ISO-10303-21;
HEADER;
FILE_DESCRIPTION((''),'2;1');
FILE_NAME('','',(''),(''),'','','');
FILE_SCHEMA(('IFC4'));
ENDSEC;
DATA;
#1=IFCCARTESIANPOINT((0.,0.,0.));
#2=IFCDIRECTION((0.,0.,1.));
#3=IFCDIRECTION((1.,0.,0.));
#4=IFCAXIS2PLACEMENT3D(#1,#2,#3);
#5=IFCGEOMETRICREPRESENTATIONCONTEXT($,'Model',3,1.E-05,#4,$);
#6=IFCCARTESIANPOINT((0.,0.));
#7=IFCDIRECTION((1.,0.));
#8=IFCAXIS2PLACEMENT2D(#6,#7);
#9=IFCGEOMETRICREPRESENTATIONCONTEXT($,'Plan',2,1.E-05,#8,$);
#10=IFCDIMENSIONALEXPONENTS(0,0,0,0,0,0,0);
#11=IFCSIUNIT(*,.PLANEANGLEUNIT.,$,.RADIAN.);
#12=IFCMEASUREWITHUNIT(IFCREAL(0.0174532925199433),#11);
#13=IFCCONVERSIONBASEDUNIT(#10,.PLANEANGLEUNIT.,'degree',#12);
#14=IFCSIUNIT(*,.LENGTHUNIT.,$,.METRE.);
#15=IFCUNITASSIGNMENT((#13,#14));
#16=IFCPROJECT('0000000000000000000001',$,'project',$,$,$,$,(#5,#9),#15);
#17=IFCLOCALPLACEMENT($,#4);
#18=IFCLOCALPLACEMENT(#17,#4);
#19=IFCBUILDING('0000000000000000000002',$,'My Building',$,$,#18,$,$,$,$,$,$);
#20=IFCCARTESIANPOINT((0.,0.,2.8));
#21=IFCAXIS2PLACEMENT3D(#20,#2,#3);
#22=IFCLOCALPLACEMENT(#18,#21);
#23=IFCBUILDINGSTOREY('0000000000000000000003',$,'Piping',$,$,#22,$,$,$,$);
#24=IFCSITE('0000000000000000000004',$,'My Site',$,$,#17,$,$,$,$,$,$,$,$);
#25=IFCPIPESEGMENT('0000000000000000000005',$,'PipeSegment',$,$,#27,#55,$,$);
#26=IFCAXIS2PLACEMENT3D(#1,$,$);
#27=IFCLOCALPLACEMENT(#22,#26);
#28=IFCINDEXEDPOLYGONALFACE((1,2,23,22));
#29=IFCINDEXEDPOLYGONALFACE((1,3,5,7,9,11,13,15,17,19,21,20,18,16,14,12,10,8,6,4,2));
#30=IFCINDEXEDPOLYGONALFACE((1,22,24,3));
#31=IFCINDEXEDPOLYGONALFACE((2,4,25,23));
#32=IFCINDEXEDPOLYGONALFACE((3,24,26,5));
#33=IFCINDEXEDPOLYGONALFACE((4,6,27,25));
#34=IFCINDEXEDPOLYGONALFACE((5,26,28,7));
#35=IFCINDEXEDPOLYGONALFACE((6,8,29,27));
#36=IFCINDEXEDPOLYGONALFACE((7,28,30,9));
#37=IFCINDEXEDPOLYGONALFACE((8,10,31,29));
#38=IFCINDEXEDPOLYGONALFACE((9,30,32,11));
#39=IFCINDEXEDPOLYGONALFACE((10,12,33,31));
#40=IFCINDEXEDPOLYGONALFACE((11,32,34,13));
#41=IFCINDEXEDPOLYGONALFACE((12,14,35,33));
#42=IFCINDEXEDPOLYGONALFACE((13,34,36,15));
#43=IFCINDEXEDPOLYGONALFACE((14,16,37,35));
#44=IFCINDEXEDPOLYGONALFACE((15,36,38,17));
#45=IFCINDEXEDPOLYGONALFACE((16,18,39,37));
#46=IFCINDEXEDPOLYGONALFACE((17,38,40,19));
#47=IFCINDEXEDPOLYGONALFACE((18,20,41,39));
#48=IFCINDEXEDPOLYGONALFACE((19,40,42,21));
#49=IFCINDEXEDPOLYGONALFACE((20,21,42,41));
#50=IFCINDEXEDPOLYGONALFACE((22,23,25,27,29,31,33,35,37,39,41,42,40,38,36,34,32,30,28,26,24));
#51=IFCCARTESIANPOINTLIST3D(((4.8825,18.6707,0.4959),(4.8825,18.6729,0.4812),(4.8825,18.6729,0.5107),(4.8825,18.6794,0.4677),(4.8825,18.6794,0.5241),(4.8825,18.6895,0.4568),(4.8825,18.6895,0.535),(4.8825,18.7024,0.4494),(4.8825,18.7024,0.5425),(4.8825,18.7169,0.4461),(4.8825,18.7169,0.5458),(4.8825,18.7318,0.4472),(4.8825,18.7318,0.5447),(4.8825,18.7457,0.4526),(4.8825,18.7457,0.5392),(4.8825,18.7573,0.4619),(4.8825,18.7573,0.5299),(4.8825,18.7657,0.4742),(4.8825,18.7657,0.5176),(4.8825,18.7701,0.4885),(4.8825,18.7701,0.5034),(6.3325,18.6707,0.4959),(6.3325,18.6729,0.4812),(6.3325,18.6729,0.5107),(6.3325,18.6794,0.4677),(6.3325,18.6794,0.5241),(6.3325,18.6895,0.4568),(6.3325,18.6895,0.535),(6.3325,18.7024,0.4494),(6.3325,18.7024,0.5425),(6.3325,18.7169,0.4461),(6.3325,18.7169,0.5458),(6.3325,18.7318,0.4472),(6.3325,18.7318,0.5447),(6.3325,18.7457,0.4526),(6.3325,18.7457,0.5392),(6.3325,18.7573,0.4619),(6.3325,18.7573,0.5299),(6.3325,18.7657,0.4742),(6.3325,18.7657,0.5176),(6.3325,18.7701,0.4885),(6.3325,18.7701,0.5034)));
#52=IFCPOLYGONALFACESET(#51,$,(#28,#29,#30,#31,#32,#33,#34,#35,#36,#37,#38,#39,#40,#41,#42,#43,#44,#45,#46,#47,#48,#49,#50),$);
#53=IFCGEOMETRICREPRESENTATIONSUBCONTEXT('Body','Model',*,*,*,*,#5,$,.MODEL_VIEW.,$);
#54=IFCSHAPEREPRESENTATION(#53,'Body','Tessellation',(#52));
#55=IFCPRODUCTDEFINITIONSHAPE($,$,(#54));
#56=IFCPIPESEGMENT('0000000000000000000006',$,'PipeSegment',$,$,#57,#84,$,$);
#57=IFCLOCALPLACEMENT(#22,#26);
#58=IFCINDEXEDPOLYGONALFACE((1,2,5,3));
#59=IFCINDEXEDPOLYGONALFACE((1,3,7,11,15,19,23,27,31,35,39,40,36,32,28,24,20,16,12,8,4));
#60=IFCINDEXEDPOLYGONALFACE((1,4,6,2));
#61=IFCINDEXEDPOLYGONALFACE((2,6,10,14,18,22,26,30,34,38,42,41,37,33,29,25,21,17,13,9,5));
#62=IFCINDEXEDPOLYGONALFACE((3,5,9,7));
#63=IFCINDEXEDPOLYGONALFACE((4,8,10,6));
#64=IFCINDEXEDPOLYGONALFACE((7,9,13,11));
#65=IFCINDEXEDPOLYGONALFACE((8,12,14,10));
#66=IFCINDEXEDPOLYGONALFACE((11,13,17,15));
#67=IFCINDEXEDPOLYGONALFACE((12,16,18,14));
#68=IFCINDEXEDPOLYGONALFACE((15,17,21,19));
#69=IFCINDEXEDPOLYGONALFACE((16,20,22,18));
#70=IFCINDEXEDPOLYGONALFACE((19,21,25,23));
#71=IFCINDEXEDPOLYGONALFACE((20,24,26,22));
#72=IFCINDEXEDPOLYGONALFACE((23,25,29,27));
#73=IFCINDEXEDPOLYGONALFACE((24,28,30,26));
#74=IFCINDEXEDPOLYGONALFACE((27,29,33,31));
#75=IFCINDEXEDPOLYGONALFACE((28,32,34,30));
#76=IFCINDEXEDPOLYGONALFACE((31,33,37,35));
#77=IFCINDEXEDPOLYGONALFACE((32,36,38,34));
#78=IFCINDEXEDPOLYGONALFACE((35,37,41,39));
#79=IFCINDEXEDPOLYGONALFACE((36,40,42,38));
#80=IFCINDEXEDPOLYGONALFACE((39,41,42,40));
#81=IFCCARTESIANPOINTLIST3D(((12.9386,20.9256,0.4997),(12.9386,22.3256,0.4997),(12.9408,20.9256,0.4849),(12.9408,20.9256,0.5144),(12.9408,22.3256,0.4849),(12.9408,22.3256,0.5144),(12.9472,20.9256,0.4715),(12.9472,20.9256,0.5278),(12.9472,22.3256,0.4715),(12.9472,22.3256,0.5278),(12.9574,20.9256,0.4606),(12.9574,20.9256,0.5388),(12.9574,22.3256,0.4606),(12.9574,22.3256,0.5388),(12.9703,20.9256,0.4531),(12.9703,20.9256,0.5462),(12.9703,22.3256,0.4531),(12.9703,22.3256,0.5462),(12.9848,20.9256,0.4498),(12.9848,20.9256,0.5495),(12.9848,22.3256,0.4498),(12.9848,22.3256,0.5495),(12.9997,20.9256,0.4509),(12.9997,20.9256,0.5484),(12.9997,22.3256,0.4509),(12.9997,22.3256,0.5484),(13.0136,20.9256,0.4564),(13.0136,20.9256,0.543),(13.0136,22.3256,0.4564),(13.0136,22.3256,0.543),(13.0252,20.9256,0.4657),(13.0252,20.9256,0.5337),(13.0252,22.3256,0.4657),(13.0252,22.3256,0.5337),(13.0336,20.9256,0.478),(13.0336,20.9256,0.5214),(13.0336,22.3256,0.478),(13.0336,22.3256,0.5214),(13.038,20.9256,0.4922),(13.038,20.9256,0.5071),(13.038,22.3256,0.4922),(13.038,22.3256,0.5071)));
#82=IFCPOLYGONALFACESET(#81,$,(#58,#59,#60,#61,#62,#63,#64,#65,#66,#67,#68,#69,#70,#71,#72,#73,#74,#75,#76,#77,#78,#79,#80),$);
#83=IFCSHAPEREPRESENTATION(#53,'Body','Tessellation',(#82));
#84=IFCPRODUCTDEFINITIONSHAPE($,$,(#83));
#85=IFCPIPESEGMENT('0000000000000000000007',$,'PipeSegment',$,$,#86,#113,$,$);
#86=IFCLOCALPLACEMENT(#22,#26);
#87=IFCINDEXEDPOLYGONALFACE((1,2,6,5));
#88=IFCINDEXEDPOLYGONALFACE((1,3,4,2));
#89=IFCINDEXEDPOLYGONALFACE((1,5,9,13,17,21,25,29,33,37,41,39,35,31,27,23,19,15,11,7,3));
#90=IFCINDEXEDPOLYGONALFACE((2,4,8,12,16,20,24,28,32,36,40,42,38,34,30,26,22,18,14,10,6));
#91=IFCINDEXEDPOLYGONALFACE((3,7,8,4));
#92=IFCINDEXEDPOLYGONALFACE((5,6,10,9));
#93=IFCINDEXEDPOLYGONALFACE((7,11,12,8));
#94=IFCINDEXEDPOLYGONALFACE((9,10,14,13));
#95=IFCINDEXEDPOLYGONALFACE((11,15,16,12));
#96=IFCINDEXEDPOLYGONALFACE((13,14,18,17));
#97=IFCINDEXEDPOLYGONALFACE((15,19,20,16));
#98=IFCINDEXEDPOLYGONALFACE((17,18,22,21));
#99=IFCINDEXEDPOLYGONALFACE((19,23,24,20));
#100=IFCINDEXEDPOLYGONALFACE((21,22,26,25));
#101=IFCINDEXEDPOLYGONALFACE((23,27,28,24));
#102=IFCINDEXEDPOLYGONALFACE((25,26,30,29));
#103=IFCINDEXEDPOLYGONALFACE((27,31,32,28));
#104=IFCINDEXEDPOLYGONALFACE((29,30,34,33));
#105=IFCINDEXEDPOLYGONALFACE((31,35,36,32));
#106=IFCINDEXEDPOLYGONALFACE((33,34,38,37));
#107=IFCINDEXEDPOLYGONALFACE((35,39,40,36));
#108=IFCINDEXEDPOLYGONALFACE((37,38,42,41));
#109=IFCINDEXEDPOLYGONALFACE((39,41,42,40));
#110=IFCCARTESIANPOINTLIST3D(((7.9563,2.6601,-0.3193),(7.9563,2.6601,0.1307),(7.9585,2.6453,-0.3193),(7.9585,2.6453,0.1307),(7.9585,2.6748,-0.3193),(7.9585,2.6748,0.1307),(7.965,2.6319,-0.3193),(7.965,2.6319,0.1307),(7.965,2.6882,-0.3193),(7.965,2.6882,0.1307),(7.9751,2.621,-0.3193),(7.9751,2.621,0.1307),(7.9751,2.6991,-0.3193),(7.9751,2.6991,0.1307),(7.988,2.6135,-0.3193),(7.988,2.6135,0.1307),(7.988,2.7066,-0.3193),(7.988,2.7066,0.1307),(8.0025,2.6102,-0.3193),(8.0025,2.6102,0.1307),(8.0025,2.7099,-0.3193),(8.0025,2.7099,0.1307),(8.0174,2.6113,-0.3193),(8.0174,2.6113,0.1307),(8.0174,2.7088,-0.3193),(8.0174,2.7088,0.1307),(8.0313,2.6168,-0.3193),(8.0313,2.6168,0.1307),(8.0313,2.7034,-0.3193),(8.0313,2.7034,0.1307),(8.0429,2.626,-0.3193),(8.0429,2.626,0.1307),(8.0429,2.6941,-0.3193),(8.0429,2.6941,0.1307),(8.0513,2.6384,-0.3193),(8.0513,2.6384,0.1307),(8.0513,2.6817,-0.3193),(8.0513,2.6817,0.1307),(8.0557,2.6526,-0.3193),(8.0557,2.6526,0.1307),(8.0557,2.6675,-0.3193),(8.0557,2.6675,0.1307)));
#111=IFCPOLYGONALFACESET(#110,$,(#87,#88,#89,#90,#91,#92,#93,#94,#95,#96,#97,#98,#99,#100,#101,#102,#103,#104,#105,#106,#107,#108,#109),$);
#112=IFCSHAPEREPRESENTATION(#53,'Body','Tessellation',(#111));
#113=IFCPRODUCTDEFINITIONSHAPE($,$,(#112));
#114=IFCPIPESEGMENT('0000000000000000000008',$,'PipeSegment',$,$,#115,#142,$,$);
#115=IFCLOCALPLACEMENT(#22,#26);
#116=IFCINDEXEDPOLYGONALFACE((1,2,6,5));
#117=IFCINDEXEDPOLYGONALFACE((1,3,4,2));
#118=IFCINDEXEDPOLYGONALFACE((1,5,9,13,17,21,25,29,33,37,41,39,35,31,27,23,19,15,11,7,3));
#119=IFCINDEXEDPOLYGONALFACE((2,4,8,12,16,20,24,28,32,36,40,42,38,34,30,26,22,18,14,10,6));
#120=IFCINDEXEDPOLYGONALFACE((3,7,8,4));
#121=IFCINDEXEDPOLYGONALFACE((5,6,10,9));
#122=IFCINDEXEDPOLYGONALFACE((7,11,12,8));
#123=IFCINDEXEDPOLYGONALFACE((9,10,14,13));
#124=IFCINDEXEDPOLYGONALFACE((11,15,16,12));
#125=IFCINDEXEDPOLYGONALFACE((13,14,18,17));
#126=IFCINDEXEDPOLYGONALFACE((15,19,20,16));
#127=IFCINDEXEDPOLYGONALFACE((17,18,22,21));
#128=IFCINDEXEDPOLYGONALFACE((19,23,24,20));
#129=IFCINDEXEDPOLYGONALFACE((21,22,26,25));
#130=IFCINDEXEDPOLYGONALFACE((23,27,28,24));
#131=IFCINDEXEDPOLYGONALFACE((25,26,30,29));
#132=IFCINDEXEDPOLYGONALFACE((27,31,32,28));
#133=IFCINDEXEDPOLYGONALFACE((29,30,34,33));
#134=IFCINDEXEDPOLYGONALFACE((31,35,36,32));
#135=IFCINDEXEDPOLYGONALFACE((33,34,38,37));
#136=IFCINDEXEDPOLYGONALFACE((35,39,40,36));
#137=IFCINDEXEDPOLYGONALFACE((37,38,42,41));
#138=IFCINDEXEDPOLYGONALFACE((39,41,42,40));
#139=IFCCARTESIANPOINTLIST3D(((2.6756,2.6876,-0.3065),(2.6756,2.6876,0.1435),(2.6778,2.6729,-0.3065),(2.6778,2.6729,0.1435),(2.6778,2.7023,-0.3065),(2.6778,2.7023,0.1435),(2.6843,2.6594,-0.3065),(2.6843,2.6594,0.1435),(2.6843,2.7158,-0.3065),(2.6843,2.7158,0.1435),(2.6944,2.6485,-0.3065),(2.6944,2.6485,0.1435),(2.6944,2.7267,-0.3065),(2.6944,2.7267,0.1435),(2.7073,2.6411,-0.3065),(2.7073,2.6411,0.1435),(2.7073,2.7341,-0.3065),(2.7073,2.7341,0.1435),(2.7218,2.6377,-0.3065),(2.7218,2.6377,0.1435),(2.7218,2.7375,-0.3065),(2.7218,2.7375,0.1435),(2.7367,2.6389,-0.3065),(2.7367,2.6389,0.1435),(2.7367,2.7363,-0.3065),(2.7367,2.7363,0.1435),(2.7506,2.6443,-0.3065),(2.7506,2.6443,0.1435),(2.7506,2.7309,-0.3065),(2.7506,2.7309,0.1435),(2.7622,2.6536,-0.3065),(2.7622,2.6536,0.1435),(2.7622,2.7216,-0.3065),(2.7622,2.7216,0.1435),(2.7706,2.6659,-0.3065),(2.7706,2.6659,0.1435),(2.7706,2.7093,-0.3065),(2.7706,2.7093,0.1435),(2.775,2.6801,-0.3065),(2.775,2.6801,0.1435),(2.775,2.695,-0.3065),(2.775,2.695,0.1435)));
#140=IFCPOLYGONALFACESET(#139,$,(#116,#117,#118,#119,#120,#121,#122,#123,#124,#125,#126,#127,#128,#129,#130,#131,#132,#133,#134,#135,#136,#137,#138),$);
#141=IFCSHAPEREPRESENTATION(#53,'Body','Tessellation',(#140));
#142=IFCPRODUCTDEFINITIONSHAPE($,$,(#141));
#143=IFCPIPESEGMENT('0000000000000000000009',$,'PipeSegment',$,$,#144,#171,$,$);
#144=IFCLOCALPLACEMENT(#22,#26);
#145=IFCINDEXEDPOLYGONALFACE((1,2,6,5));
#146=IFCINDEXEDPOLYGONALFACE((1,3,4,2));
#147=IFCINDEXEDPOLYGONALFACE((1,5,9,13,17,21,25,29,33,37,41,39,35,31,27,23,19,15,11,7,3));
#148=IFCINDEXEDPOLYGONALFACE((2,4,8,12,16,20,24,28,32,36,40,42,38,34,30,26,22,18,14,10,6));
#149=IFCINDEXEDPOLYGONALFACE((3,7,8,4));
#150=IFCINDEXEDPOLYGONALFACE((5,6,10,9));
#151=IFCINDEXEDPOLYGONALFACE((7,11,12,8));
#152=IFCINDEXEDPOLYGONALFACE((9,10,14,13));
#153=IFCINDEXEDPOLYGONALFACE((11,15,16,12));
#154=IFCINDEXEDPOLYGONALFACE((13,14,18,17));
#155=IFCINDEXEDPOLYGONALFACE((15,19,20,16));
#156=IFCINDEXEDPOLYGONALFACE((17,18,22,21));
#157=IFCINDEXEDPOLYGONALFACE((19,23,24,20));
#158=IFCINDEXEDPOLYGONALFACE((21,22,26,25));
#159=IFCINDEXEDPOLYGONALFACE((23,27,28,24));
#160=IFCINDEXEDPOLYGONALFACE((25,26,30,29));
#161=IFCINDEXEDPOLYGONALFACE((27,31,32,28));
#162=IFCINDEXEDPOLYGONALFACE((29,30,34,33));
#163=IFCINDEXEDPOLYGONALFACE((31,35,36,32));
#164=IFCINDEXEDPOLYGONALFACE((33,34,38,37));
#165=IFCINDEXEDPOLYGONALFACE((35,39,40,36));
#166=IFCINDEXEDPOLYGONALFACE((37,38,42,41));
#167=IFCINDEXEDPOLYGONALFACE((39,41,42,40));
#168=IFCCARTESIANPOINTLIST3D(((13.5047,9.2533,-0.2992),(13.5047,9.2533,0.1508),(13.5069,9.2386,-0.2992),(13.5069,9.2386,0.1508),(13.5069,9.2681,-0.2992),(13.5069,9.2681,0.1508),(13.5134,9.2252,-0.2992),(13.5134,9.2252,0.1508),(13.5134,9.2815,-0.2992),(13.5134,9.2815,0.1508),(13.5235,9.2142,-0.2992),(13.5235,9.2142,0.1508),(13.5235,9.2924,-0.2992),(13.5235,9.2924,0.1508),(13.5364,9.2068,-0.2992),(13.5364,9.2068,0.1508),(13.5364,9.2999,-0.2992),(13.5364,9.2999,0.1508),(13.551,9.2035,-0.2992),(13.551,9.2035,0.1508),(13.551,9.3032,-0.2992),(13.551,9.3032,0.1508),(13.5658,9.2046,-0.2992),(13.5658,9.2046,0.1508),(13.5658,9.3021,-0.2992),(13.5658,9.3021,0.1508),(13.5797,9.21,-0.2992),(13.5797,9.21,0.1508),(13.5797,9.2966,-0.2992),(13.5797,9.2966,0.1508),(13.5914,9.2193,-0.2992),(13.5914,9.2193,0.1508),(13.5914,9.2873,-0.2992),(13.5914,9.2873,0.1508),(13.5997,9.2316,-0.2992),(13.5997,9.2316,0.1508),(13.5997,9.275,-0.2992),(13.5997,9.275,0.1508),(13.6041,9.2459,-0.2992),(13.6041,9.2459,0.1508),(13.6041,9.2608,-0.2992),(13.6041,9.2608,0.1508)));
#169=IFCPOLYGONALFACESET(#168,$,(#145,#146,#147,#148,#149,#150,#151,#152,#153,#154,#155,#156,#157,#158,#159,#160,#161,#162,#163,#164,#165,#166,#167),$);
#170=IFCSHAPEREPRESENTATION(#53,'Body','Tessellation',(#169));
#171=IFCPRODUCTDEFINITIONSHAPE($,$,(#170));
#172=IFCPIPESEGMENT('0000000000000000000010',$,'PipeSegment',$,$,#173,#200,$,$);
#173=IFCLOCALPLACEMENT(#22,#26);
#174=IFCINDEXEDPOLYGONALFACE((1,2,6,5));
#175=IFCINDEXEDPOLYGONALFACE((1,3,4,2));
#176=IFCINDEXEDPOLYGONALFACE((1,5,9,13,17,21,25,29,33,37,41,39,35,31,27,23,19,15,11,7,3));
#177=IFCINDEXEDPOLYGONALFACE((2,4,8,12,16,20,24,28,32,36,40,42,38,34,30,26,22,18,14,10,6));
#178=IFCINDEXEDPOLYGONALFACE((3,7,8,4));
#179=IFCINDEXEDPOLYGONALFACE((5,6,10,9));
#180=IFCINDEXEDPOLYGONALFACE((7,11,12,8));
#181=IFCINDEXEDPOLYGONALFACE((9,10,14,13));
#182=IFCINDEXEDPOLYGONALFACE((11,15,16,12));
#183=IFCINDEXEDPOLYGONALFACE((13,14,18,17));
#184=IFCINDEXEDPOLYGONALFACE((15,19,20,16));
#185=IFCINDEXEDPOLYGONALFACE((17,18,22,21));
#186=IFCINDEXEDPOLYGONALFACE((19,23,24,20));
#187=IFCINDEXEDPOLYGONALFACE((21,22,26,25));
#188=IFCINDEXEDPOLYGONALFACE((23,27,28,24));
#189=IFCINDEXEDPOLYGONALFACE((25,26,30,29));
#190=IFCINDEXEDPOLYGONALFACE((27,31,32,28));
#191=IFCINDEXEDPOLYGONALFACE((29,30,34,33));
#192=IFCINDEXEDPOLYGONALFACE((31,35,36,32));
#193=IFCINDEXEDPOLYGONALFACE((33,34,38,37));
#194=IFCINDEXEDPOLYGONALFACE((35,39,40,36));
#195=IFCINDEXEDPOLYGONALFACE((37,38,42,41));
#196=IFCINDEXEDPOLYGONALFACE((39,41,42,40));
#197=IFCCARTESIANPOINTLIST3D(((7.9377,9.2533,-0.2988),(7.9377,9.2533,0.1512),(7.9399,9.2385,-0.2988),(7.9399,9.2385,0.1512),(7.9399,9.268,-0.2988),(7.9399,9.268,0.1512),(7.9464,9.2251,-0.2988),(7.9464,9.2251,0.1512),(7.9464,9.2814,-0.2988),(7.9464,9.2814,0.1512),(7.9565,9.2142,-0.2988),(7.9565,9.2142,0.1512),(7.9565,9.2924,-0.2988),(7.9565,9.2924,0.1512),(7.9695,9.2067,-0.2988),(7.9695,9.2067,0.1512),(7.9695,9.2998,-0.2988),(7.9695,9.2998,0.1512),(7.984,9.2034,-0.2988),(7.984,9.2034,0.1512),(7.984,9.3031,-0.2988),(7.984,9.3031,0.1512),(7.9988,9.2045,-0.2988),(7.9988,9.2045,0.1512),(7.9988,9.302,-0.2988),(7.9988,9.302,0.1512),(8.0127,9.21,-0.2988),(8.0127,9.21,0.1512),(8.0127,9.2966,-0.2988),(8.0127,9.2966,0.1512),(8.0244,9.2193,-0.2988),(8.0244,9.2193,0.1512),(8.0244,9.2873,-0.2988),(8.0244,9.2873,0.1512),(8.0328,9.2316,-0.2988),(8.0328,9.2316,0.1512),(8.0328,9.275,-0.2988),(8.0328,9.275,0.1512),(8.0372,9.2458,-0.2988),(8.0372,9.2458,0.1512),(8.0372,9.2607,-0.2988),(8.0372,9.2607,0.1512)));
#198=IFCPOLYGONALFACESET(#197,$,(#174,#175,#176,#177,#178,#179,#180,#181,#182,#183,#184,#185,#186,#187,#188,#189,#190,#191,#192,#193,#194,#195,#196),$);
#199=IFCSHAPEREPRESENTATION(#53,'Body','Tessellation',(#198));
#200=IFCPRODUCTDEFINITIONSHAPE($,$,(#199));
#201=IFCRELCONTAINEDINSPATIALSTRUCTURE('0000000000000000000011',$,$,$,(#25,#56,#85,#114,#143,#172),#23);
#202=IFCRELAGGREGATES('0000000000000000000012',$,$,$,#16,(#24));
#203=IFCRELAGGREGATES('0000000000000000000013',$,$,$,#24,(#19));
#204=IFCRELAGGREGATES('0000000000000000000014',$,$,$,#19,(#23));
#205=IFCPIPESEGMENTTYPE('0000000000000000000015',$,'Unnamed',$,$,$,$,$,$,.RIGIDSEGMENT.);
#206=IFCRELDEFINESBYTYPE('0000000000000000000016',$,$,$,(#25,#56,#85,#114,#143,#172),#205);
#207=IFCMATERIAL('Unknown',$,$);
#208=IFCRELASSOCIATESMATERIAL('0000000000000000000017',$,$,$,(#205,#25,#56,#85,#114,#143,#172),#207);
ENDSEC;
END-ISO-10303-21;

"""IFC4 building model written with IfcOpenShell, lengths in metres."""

from ifc_helpers import new_model, entity, si_unit, converted_unit, frame, origin_with_axes, origin_2d_with_axis, place, context, subcontext, project, spatial, circle, extrude, material, material_profile, profile_set, profile_usage, type_object, element, save


model = new_model("IFC4")

# Units and contexts
model_context = context("Model", 3, precision=1e-05, world=origin_with_axes())
plan_context = context("Plan", 2, precision=1e-05, world=origin_2d_with_axis())
body_context = subcontext(model_context, "Body", "Model", "MODEL_VIEW")
ifc_project = project(units=[converted_unit("PLANEANGLEUNIT", "degree", entity("IfcReal", 0.0174532925199433), si_unit("PLANEANGLEUNIT", "RADIAN"), dimensions=[0, 0, 0, 0, 0, 0, 0]), si_unit("LENGTHUNIT", "METRE")], contexts=[model_context, plan_context])

# Site, building, storey
site_placement = place(None, origin_with_axes())
site = spatial("IfcSite", under=ifc_project, at=site_placement, Name="My Site")
building_placement = place(site_placement, origin_with_axes())
building = spatial("IfcBuilding", under=site, at=building_placement, Name="My Building")
storey_placement = place(building_placement, frame((0.0, 0.0, 2.8), z_axis=(0.0, 0.0, 1.0), x_axis=(1.0, 0.0, 0.0)))
storey = spatial("IfcBuildingStorey", under=building, at=storey_placement, Name="Piping")

# Pipe segments
ifc_material = material(Name="Unknown")
ifc_material_profile_1 = material_profile(ifc_material, circle(Radius=0.05))
ifc_profile_set_1 = profile_set([ifc_material_profile_1])
pipe_segment_type = type_object("IfcPipeSegmentType", Name="Unnamed", PredefinedType="RIGIDSEGMENT", material=ifc_profile_set_1)
ifc_profile_usage_1 = profile_usage(ifc_profile_set_1, cardinal=5)
pipe_segment_1_placement = place(storey_placement, frame((6.3325, 18.7207, 0.4959), z_axis=(-1.0, 0.0, 0.0), x_axis=(0.0, -1.0, 0.0)))
element("IfcPipeSegment", 1, at=pipe_segment_1_placement, inside=storey, type_object=pipe_segment_type, material=ifc_profile_usage_1, Name="PipeSegment", context=body_context, shape_type="SweptSolid", body=[
    extrude(circle(Radius=0.05), origin_with_axes(), (0.0, 0.0, 1.0), 1.45),
])
ifc_profile_usage_2 = profile_usage(ifc_profile_set_1, cardinal=5)
pipe_segment_2_placement = place(storey_placement, frame((12.9886, 20.9256, 0.4997), z_axis=(0.0, 1.0, 0.0), x_axis=(-1.0, 0.0, 0.0)))
element("IfcPipeSegment", 2, at=pipe_segment_2_placement, inside=storey, type_object=pipe_segment_type, material=ifc_profile_usage_2, Name="PipeSegment", context=body_context, shape_type="SweptSolid", body=[
    extrude(circle(Radius=0.05), origin_with_axes(), (0.0, 0.0, 1.0), 1.4),
])
ifc_profile_usage_3 = profile_usage(ifc_profile_set_1, cardinal=5)
pipe_segment_3_placement = place(storey_placement, frame((8.0063, 2.6601, 0.1307), z_axis=(0.0, 0.0, -1.0), x_axis=(-1.0, 0.0, 0.0)))
element("IfcPipeSegment", 3, at=pipe_segment_3_placement, inside=storey, type_object=pipe_segment_type, material=ifc_profile_usage_3, Name="PipeSegment", context=body_context, shape_type="SweptSolid", body=[
    extrude(circle(Radius=0.05), origin_with_axes(), (0.0, 0.0, 1.0), 0.45),
])
ifc_profile_usage_4 = profile_usage(ifc_profile_set_1, cardinal=5)
pipe_segment_4_placement = place(storey_placement, frame((2.7256, 2.6876, 0.1435), z_axis=(0.0, 0.0, -1.0), x_axis=(-1.0, 0.0, 0.0)))
element("IfcPipeSegment", 4, at=pipe_segment_4_placement, inside=storey, type_object=pipe_segment_type, material=ifc_profile_usage_4, Name="PipeSegment", context=body_context, shape_type="SweptSolid", body=[
    extrude(circle(Radius=0.05), origin_with_axes(), (0.0, 0.0, 1.0), 0.45),
])
ifc_profile_usage_5 = profile_usage(ifc_profile_set_1, cardinal=5)
pipe_segment_5_placement = place(storey_placement, frame((13.5547, 9.2533, 0.1508), z_axis=(0.0, 0.0, -1.0), x_axis=(-1.0, 0.0, 0.0)))
element("IfcPipeSegment", 5, at=pipe_segment_5_placement, inside=storey, type_object=pipe_segment_type, material=ifc_profile_usage_5, Name="PipeSegment", context=body_context, shape_type="SweptSolid", body=[
    extrude(circle(Radius=0.05), origin_with_axes(), (0.0, 0.0, 1.0), 0.45),
])
ifc_profile_usage_6 = profile_usage(ifc_profile_set_1, cardinal=5)
pipe_segment_6_placement = place(storey_placement, frame((7.9877, 9.2533, 0.1512), z_axis=(0.0, 0.0, -1.0), x_axis=(-1.0, 0.0, 0.0)))
element("IfcPipeSegment", 6, at=pipe_segment_6_placement, inside=storey, type_object=pipe_segment_type, material=ifc_profile_usage_6, Name="PipeSegment", context=body_context, shape_type="SweptSolid", body=[
    extrude(circle(Radius=0.05), origin_with_axes(), (0.0, 0.0, 1.0), 0.45),
])

save(model, "model.ifc")
